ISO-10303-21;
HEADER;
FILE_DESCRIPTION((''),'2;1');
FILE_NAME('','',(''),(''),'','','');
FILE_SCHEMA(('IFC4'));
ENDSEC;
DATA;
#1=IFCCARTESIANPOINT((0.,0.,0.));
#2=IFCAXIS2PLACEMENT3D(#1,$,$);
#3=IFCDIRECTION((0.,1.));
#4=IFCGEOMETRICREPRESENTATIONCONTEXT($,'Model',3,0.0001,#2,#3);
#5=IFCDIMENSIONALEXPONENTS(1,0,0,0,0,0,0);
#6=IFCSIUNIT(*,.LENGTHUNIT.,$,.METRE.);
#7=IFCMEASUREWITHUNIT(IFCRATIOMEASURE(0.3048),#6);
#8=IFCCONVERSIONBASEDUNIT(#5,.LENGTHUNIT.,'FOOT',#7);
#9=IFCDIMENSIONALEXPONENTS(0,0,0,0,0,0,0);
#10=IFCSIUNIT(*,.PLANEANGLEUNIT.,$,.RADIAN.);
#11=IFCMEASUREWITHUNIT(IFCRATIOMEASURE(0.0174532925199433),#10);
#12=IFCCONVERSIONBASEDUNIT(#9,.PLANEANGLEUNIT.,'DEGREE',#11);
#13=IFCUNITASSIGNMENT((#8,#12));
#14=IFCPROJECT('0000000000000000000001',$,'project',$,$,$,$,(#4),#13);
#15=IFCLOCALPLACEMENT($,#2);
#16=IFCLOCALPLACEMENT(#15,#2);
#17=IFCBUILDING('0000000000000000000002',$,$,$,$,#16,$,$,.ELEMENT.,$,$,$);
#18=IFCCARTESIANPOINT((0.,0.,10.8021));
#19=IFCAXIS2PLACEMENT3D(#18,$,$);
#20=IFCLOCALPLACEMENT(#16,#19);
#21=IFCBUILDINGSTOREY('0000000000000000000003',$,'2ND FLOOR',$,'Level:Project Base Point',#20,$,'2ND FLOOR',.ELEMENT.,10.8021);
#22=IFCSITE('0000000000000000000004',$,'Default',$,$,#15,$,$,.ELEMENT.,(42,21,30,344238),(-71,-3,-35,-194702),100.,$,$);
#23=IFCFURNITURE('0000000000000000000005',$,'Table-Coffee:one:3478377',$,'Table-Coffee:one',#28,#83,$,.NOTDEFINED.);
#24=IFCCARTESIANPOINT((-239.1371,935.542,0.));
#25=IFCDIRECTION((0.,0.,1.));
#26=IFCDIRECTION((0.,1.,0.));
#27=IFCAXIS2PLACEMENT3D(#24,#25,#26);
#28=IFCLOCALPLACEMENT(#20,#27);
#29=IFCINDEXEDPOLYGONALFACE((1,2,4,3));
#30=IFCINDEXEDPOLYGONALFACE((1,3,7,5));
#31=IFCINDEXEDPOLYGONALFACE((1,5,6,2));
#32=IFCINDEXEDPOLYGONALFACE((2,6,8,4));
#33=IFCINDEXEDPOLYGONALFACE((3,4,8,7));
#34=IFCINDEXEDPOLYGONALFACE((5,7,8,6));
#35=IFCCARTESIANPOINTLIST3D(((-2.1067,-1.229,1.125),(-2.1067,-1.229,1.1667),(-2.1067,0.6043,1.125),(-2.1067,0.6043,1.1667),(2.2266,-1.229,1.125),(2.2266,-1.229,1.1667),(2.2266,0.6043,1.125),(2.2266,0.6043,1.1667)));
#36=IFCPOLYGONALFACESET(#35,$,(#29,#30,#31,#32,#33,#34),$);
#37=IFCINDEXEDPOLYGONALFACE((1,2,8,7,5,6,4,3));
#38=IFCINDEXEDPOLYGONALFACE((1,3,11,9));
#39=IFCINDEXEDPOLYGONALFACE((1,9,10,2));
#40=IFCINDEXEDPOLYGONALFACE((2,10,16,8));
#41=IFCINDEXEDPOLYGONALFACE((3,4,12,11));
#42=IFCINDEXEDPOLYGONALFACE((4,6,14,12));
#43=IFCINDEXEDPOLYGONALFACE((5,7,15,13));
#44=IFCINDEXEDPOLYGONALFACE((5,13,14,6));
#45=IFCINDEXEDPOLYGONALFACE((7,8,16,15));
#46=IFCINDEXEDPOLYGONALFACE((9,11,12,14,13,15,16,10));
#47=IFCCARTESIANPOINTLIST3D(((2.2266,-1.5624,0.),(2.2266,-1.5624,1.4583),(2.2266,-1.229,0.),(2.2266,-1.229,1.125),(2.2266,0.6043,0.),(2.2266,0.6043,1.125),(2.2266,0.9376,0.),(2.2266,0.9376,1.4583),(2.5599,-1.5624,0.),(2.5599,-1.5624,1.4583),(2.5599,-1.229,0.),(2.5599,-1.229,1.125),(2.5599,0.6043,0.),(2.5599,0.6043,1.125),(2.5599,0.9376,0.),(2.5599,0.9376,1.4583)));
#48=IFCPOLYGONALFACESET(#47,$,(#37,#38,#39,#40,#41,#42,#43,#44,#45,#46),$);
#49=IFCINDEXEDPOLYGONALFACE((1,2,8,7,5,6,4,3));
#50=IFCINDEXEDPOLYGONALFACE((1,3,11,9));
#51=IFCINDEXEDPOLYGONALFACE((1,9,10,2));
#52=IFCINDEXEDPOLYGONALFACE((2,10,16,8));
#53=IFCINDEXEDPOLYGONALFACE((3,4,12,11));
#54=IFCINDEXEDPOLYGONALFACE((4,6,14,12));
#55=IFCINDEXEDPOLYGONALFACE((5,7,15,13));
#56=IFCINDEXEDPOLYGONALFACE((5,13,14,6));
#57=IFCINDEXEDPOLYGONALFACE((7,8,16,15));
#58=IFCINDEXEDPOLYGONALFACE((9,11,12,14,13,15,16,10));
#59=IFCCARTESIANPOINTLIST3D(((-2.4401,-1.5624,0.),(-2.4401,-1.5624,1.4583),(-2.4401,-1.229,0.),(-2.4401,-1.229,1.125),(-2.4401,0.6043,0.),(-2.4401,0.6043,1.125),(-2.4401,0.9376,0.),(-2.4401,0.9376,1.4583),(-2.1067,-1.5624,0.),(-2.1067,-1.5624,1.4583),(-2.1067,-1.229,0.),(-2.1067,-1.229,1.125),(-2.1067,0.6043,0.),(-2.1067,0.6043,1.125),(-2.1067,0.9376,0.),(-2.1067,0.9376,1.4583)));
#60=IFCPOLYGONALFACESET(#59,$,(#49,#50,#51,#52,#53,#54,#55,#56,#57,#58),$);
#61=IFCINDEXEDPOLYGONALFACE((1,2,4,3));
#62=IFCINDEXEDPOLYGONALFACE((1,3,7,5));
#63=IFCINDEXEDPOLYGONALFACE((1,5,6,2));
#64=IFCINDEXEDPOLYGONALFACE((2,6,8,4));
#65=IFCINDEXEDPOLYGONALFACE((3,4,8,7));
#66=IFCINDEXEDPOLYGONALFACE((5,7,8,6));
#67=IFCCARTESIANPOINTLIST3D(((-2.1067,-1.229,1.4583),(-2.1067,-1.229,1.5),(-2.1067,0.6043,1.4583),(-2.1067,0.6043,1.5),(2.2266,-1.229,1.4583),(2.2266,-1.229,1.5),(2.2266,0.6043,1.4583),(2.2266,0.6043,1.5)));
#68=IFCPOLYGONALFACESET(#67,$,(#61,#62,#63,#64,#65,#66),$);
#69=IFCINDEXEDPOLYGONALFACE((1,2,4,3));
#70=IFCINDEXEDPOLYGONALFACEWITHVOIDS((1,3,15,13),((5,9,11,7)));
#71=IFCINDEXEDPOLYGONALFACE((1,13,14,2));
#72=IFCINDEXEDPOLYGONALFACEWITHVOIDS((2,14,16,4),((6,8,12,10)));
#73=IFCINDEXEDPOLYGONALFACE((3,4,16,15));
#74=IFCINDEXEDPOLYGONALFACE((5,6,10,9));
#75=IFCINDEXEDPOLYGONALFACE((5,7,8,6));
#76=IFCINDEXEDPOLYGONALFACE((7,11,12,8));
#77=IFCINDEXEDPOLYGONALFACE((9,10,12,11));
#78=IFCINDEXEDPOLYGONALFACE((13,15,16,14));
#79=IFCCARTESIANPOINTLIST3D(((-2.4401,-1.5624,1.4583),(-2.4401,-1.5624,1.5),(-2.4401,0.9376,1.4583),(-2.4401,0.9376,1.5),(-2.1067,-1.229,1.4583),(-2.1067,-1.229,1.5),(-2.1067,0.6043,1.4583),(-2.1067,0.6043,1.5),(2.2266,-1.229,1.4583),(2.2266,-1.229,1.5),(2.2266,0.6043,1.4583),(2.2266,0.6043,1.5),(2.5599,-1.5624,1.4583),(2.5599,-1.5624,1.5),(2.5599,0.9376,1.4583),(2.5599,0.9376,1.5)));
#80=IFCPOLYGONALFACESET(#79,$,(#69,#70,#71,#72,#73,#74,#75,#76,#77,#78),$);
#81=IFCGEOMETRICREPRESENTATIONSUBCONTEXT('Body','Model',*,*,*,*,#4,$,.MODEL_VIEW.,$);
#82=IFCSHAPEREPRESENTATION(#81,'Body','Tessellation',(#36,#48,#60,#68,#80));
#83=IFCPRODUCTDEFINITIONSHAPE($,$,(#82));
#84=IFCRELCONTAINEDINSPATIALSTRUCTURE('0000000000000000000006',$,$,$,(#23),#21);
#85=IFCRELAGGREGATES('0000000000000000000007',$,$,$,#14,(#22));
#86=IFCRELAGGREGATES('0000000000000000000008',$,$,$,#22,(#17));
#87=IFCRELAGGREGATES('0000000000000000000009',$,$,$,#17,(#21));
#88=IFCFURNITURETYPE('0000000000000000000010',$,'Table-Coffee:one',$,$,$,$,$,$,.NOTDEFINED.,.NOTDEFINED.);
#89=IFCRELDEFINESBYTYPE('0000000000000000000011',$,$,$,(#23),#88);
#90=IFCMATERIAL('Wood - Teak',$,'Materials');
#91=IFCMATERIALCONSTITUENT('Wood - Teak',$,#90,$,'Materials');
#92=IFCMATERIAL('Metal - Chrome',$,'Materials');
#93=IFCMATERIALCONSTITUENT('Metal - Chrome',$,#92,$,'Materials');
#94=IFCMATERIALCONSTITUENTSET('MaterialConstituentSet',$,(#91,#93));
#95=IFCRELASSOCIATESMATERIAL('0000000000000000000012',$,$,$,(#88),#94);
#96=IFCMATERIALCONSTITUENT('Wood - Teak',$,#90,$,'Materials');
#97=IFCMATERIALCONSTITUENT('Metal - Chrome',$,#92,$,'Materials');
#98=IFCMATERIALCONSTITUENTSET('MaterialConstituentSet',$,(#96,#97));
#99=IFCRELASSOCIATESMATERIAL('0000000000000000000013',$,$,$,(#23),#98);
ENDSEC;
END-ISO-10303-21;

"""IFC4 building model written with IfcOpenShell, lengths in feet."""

from ifc_helpers import new_model, entity, si_unit, converted_unit, direction, frame, origin, origin_2d_with_axis, place, context, subcontext, project, spatial, polyline, rectangle, outline, extrude, source, transform, mapped, material, constituent, constituent_set, type_object, type_shapes, element, save


model = new_model("IFC4")

# Units and contexts
model_context = context("Model", 3, precision=0.0001, world=origin(), true_north=direction((0.0, 1.0)))
body_context = subcontext(model_context, "Body", "Model", "MODEL_VIEW")
ifc_project = project(units=[converted_unit("LENGTHUNIT", "FOOT", entity("IfcRatioMeasure", 0.3048), si_unit("LENGTHUNIT", "METRE"), dimensions=[1, 0, 0, 0, 0, 0, 0]), converted_unit("PLANEANGLEUNIT", "DEGREE", entity("IfcRatioMeasure", 0.0174532925199433), si_unit("PLANEANGLEUNIT", "RADIAN"), dimensions=[0, 0, 0, 0, 0, 0, 0])], contexts=[model_context])

# Site, building, storey
site_placement = place(None, origin())
site = spatial("IfcSite", under=ifc_project, at=site_placement, Name="Default", CompositionType="ELEMENT", RefLatitude=(42, 21, 30, 344238), RefLongitude=(-71, -3, -35, -194702), RefElevation=100.0)
building_placement = place(site_placement, origin())
building = spatial("IfcBuilding", under=site, at=building_placement, CompositionType="ELEMENT")
storey_placement = place(building_placement, frame((0.0, 0.0, 10.8021)))
storey = spatial("IfcBuildingStorey", under=building, at=storey_placement, Name="2ND FLOOR", ObjectType="Level:Project Base Point", LongName="2ND FLOOR", CompositionType="ELEMENT", Elevation=10.8021)

# Furniture
ifc_material_1 = material(Name="Wood - Teak", Category="Materials")
ifc_constituent_1 = constituent(ifc_material_1, Name="Wood - Teak", Category="Materials")
ifc_material_2 = material(Name="Metal - Chrome", Category="Materials")
ifc_constituent_2 = constituent(ifc_material_2, Name="Metal - Chrome", Category="Materials")
ifc_constituent_set_1 = constituent_set(constituents=[ifc_constituent_1, ifc_constituent_2], Name="MaterialConstituentSet")
ifc_constituent_3 = constituent(ifc_material_1, Name="Wood - Teak", Category="Materials")
ifc_constituent_4 = constituent(ifc_material_2, Name="Metal - Chrome", Category="Materials")
ifc_constituent_set_2 = constituent_set(constituents=[ifc_constituent_3, ifc_constituent_4], Name="MaterialConstituentSet")
furniture_type_1 = type_object("IfcFurnitureType", Name="Table-Coffee:one", AssemblyPlace="NOTDEFINED", PredefinedType="NOTDEFINED", material=ifc_constituent_set_2)
shared_shape_1 = source(origin(), body_context, "Body", "SweptSolid", [
    extrude(rectangle(XDim=1.8333, YDim=4.3333, at=origin_2d_with_axis()), frame((0.0599, -0.3124, 1.125), z_axis=(0.0, 0.0, 1.0), x_axis=(0.0, 1.0, 0.0)), (0.0, 0.0, 1.0), 0.0417),
    extrude(outline(polyline([(-1.25, -0.6458), (-0.9167, -0.6458), (-0.9167, 0.4792), (0.9167, 0.4792), (0.9167, -0.6458), (1.25, -0.6458), (1.25, 0.8125), (-1.25, 0.8125), (-1.25, -0.6458)])), frame((2.2266, -0.3124, 0.6458), z_axis=(1.0, 0.0, 0.0), x_axis=(0.0, 1.0, 0.0)), (0.0, 0.0, 1.0), 0.3333),
    extrude(outline(polyline([(-0.8125, -1.25), (0.6458, -1.25), (0.6458, -0.9167), (-0.4792, -0.9167), (-0.4792, 0.9167), (0.6458, 0.9167), (0.6458, 1.25), (-0.8125, 1.25), (-0.8125, -1.25)])), frame((-2.4401, -0.3124, 0.6458), z_axis=(1.0, 0.0, 0.0), x_axis=(0.0, 0.0, -1.0)), (0.0, 0.0, 1.0), 0.3333),
    extrude(rectangle(XDim=1.8333, YDim=4.3333, at=origin_2d_with_axis()), frame((0.0599, -0.3124, 1.4583), z_axis=(0.0, 0.0, 1.0), x_axis=(0.0, 1.0, 0.0)), (0.0, 0.0, 1.0), 0.0417),
    extrude(outline(polyline([(-1.25, -2.5), (1.25, -2.5), (1.25, 2.5), (-1.25, 2.5), (-1.25, -2.5)]), holes=[polyline([(-0.9167, -2.1667), (-0.9167, 2.1667), (0.9167, 2.1667), (0.9167, -2.1667), (-0.9167, -2.1667)])]), frame((0.0599, -0.3124, 1.4583), z_axis=(0.0, 0.0, 1.0), x_axis=(0.0, 1.0, 0.0)), (0.0, 0.0, 1.0), 0.0417),
])
type_shapes(furniture_type_1, [shared_shape_1])
furniture_1_placement = place(storey_placement, frame((-239.1371, 935.542, 0.0), z_axis=(0.0, 0.0, 1.0), x_axis=(0.0, 1.0, 0.0)))
element("IfcFurniture", 1, at=furniture_1_placement, inside=storey, type_object=furniture_type_1, material=ifc_constituent_set_1, Name="Table-Coffee:one:3478377", ObjectType="Table-Coffee:one", PredefinedType="NOTDEFINED", context=body_context, shape_type="MappedRepresentation", body=[
    mapped(shared_shape_1, transform((0.0, 0.0, 0.0), scale=1.0)),
])

save(model, "model.ifc")
